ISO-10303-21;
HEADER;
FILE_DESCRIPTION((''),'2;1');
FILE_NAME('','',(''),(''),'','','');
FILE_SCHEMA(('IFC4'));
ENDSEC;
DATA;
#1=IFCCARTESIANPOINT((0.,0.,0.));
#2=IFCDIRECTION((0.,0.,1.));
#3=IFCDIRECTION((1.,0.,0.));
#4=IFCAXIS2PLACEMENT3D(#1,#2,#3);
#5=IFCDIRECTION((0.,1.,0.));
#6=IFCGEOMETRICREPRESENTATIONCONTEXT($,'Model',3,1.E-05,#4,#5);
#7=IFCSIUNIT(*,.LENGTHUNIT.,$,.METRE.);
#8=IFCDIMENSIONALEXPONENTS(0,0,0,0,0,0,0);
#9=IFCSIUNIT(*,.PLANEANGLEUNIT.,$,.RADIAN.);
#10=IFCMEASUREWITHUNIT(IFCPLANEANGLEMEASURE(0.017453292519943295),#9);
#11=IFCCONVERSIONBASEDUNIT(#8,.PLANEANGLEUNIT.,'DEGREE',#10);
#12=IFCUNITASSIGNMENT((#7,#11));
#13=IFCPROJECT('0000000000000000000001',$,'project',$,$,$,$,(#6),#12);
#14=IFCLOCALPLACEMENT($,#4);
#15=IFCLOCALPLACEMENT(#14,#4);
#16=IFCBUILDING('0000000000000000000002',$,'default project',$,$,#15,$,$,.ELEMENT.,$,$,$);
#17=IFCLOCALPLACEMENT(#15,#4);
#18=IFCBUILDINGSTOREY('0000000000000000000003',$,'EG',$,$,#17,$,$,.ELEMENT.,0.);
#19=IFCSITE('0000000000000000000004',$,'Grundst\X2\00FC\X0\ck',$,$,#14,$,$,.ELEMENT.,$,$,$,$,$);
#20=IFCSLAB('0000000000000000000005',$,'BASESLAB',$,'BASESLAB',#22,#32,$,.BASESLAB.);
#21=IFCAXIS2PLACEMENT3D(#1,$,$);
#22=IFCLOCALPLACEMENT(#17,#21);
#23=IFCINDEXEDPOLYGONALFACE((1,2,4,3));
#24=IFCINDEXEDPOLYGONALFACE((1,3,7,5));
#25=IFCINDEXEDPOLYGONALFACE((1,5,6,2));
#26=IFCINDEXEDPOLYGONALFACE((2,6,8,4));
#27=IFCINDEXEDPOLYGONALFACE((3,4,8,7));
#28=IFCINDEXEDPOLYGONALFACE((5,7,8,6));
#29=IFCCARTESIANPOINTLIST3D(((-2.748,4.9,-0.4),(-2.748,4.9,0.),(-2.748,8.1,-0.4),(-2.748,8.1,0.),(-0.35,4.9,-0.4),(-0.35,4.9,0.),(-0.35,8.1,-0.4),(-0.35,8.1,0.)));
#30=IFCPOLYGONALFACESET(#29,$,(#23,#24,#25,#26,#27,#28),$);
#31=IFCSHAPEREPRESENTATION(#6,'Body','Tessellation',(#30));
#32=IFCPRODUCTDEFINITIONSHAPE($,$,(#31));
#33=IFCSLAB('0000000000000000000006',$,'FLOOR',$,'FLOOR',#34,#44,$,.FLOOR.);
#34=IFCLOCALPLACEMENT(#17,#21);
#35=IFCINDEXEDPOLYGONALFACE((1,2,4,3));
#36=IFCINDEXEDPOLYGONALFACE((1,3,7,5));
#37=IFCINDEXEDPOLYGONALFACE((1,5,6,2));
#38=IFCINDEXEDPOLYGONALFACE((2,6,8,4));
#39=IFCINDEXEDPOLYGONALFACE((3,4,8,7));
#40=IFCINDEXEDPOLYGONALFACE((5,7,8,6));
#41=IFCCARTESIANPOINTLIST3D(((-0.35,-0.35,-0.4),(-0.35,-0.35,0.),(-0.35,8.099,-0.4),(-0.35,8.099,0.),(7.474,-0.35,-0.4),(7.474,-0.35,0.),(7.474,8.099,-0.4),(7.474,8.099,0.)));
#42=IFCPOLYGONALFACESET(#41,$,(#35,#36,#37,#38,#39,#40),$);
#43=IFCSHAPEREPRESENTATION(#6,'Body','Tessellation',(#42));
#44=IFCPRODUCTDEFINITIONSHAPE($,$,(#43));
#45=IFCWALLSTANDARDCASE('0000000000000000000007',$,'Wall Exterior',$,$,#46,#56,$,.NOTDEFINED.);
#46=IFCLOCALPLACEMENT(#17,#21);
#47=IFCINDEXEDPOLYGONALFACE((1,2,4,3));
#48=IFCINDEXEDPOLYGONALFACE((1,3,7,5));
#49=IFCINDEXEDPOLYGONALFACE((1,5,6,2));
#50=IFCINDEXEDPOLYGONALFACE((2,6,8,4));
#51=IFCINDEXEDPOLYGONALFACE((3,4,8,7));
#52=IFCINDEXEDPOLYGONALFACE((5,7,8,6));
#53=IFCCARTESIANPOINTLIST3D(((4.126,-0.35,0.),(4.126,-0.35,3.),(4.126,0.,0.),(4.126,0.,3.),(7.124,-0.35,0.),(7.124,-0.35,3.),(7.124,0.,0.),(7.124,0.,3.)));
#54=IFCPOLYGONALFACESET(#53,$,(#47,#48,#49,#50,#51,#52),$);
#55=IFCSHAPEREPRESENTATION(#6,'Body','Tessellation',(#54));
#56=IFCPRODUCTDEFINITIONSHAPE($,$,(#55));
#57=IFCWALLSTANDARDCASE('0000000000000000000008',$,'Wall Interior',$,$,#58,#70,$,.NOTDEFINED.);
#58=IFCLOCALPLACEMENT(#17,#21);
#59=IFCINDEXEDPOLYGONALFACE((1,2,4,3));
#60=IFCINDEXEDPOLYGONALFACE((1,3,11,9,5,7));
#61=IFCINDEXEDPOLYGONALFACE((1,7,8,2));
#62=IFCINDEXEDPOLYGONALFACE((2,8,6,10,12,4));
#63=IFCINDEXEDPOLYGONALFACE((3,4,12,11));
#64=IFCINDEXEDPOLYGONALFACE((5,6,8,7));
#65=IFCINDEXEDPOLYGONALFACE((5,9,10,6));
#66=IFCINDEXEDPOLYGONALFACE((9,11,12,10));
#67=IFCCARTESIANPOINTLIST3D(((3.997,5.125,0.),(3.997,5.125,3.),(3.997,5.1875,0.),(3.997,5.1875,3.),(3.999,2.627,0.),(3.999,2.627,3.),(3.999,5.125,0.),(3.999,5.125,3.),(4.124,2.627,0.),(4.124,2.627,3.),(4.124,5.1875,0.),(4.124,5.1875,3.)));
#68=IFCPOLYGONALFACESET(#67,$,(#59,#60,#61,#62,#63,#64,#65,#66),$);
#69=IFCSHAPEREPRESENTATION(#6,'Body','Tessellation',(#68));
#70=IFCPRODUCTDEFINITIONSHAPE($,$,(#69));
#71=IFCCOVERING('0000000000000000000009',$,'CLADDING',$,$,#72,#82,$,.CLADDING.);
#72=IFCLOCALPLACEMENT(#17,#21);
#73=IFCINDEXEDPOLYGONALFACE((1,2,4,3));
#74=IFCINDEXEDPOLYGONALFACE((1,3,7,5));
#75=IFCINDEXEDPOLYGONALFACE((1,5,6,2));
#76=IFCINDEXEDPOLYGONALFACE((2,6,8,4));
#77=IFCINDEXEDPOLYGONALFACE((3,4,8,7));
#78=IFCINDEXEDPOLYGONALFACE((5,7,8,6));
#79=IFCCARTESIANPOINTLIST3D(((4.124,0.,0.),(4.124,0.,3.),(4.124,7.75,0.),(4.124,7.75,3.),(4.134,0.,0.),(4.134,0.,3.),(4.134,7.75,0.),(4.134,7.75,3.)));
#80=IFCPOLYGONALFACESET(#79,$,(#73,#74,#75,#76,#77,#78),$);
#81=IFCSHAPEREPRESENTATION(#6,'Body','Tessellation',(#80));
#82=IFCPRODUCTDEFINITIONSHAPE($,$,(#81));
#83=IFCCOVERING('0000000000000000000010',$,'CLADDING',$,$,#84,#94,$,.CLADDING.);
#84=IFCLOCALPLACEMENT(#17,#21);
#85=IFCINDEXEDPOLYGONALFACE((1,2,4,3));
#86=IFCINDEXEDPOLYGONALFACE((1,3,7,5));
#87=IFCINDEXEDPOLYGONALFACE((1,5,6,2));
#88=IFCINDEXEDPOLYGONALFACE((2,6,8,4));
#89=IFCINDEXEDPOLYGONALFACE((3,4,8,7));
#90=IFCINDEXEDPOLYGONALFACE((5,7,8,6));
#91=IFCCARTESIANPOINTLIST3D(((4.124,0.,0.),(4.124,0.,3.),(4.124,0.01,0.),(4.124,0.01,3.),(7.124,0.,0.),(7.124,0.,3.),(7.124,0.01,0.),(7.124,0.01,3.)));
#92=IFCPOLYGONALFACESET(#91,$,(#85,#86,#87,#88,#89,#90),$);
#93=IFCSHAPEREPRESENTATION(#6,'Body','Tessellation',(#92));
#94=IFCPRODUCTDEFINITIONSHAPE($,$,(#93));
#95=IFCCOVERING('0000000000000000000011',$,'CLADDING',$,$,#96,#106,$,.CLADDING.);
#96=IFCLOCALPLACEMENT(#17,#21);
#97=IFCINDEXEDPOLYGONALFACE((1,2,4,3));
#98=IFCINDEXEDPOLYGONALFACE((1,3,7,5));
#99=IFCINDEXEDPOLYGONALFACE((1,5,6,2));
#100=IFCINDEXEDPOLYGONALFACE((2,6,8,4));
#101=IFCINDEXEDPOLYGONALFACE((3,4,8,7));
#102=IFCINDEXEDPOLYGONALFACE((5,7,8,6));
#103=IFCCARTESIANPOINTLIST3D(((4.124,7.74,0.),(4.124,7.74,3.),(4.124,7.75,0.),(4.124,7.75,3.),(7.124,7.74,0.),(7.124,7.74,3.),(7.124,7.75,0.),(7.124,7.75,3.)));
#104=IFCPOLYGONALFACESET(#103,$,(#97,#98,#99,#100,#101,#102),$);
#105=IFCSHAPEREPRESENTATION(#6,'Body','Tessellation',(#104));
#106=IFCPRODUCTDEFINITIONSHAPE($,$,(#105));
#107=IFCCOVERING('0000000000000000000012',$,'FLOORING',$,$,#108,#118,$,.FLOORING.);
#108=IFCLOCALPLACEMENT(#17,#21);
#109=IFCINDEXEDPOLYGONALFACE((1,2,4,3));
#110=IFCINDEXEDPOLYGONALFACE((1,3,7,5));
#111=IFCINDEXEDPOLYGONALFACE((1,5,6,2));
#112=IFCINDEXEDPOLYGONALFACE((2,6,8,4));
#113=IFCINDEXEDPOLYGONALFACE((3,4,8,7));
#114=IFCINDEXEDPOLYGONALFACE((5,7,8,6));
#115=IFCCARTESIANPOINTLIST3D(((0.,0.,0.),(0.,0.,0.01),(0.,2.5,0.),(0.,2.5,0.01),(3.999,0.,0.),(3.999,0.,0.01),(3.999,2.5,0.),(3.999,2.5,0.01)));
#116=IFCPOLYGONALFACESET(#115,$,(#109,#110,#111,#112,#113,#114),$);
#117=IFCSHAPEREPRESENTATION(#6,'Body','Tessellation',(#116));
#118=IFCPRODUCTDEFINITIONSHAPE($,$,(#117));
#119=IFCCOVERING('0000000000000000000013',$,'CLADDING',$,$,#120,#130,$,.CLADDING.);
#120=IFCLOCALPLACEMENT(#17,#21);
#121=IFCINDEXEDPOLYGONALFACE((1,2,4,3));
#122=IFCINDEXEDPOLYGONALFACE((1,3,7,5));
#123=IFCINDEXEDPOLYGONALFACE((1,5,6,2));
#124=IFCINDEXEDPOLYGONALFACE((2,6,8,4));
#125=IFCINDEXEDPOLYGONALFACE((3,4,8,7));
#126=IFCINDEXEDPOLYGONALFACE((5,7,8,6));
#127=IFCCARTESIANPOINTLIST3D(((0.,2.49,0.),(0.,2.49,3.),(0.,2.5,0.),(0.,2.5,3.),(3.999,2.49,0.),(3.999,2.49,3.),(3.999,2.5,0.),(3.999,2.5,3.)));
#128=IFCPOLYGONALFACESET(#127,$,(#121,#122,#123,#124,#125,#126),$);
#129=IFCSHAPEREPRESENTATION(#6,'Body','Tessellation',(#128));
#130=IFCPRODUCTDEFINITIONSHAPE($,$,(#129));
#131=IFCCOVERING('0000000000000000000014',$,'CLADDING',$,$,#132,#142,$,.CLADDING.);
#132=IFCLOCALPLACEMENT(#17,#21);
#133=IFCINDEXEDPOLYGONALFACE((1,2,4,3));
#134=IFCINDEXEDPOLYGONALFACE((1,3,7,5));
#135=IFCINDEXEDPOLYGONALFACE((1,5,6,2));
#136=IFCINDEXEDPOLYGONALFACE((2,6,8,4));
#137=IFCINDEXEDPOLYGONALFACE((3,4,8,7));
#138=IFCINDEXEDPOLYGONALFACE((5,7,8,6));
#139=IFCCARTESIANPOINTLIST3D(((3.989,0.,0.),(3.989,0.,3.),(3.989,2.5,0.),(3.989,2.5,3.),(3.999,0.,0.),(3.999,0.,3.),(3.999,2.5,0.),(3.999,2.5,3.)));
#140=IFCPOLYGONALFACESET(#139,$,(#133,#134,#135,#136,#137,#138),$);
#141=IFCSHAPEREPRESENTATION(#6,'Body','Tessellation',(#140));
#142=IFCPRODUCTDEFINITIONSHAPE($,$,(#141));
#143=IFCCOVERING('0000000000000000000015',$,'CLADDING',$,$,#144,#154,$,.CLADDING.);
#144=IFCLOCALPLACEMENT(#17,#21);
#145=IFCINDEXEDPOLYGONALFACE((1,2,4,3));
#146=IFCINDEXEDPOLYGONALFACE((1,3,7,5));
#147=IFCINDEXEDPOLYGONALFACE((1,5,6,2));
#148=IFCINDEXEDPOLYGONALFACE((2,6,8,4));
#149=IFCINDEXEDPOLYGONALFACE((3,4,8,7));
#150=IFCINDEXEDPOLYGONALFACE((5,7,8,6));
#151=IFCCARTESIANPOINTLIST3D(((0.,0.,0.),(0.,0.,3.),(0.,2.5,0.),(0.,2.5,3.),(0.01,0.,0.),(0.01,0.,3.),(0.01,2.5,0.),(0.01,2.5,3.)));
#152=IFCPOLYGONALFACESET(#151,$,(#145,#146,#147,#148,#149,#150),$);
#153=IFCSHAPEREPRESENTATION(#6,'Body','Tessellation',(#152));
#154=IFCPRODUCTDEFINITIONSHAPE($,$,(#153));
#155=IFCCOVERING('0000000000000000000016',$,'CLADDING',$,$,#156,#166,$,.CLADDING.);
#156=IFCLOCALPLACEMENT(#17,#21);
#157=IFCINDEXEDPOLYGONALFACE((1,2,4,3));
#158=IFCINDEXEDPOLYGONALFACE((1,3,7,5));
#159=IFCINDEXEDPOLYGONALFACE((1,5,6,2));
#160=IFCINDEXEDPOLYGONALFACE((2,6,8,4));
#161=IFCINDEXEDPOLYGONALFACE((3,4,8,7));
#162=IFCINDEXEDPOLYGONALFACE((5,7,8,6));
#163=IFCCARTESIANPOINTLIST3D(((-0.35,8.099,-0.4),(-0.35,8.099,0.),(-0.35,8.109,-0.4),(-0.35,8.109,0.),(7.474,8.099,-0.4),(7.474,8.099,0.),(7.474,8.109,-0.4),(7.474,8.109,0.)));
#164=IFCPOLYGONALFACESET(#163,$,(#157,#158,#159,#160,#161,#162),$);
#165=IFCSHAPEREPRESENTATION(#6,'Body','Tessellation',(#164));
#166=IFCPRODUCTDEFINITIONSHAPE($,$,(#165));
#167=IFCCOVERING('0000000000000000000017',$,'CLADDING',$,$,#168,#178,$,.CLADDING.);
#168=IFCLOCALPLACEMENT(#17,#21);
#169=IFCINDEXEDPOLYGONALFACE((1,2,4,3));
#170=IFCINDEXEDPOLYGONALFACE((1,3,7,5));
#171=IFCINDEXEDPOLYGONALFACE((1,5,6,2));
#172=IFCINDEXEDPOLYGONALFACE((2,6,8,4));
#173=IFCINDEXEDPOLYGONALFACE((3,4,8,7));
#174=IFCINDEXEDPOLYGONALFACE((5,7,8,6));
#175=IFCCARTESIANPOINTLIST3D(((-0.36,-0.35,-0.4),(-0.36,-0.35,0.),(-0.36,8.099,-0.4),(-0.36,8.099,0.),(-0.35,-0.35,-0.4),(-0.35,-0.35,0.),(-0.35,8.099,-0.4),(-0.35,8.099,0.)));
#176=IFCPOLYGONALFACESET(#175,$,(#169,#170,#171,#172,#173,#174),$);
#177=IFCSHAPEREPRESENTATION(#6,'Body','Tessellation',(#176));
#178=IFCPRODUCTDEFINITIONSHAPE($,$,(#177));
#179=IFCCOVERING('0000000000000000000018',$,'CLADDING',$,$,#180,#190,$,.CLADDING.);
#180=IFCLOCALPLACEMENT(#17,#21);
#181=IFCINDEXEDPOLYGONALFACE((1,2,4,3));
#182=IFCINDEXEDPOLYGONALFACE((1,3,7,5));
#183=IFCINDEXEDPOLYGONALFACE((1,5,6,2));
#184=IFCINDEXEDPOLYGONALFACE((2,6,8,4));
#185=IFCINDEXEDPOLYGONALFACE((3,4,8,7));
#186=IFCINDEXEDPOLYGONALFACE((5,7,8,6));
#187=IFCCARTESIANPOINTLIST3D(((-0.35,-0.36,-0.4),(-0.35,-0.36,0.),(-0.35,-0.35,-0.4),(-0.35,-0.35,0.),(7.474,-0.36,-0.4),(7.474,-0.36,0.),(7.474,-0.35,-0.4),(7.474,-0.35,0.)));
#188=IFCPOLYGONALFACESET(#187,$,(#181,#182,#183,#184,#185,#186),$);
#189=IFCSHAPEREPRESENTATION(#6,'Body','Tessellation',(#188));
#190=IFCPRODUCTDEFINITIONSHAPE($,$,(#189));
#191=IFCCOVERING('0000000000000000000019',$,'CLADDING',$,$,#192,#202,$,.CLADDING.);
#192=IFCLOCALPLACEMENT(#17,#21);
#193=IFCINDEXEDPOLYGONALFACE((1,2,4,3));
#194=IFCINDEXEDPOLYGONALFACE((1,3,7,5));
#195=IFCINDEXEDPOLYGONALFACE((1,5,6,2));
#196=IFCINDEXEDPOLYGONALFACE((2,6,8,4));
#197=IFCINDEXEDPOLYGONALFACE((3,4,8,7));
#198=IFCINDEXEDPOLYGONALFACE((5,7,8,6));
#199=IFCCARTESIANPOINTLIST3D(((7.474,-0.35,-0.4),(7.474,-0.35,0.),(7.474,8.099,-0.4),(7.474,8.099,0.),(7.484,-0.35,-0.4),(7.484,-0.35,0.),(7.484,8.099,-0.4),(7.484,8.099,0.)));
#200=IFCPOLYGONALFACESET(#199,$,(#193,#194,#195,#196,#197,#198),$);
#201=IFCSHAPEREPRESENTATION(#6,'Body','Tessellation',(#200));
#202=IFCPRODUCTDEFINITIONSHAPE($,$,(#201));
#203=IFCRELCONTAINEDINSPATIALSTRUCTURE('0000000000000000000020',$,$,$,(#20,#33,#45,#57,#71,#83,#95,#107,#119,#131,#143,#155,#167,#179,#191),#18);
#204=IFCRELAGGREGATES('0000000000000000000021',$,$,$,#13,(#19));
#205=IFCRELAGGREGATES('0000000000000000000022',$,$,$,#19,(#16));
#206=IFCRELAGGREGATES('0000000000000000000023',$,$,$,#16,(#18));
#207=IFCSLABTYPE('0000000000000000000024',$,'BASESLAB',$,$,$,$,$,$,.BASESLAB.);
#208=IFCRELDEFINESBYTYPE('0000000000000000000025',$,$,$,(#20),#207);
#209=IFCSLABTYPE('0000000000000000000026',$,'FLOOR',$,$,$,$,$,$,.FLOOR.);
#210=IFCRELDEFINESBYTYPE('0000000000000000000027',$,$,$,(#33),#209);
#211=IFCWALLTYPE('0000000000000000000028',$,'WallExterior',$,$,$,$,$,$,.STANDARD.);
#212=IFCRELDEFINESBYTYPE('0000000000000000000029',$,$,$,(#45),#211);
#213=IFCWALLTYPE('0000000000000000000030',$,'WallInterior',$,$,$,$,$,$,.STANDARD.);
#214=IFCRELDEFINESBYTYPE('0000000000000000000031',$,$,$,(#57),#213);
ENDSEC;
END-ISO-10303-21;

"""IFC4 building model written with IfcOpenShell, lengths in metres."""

from ifc_helpers import new_model, entity, si_unit, converted_unit, direction, frame, origin_with_axes, place, context, project, spatial, polyline, outline, extrude, type_object, element, save


model = new_model("IFC4")

# Units and contexts
model_context = context("Model", 3, precision=1e-05, world=origin_with_axes(), true_north=direction((0.0, 1.0, 0.0)))
ifc_project = project(units=[si_unit("LENGTHUNIT", "METRE"), converted_unit("PLANEANGLEUNIT", "DEGREE", entity("IfcPlaneAngleMeasure", 0.017453292519943295), si_unit("PLANEANGLEUNIT", "RADIAN"), dimensions=[0, 0, 0, 0, 0, 0, 0])], contexts=[model_context])

# Site, building, storey
site_placement = place(None, origin_with_axes())
site = spatial("IfcSite", under=ifc_project, at=site_placement, Name="Grundstück", CompositionType="ELEMENT")
building_placement = place(site_placement, origin_with_axes())
building = spatial("IfcBuilding", under=site, at=building_placement, Name="default project", CompositionType="ELEMENT")
placement_1 = place(building_placement, origin_with_axes())
storey = spatial("IfcBuildingStorey", under=building, at=placement_1, Name="EG", CompositionType="ELEMENT", Elevation=0.0)

# Slabs
slab_type_1 = type_object("IfcSlabType", Name="BASESLAB", PredefinedType="BASESLAB")
slab_1_placement = place(placement_1, frame((0.0, 0.0, -0.4), z_axis=(0.0, 0.0, 1.0), x_axis=(1.0, 0.0, 0.0)))
element("IfcSlab", 1, at=slab_1_placement, inside=storey, type_object=slab_type_1, Name="BASESLAB", ObjectType="BASESLAB", PredefinedType="BASESLAB", context=model_context, shape_type="SweptSolid", body=[
    extrude(outline(polyline([(-0.35, 8.1), (-2.748, 8.1), (-2.748, 4.9), (-0.35, 4.9), (-0.35, 8.1)])), origin_with_axes(), (0.0, 0.0, 1.0), 0.4),
])
slab_type_2 = type_object("IfcSlabType", Name="FLOOR", PredefinedType="FLOOR")
slab_2_placement = place(placement_1, frame((0.0, 0.0, -0.4), z_axis=(0.0, 0.0, 1.0), x_axis=(1.0, 0.0, 0.0)))
element("IfcSlab", 2, at=slab_2_placement, inside=storey, type_object=slab_type_2, Name="FLOOR", ObjectType="FLOOR", PredefinedType="FLOOR", context=model_context, shape_type="SweptSolid", body=[
    extrude(outline(polyline([(7.474, 8.099), (-0.35, 8.099), (-0.35, -0.35), (7.474, -0.35), (7.474, 8.099)])), origin_with_axes(), (0.0, 0.0, 1.0), 0.4),
])

# Walls
wall_type_1 = type_object("IfcWallType", Name="WallExterior", PredefinedType="STANDARD")
placement_2 = place(placement_1, frame((7.299, -0.175, 0.0), z_axis=(0.0, 0.0, 1.0), x_axis=(-1.0, 0.0, 0.0)))
element("IfcWallStandardCase", 3, at=placement_2, inside=storey, type_object=wall_type_1, Name="Wall Exterior", PredefinedType="NOTDEFINED", context=model_context, shape_type="SweptSolid", body=[
    extrude(outline(polyline([(0.175, -0.175), (3.173, -0.175), (3.173, 0.175), (0.175, 0.175), (0.175, -0.175)])), origin_with_axes(), (0.0, 0.0, 1.0), 3.0),
])
wall_type_2 = type_object("IfcWallType", Name="WallInterior", PredefinedType="STANDARD")
wall_1_placement = place(placement_1, frame((4.0615, 5.1875, 0.0), z_axis=(0.0, 0.0, 1.0), x_axis=(0.0, -1.0, 0.0)))
element("IfcWallStandardCase", 4, at=wall_1_placement, inside=storey, type_object=wall_type_2, Name="Wall Interior", PredefinedType="NOTDEFINED", context=model_context, shape_type="SweptSolid", body=[
    extrude(outline(polyline([(0.0, 0.0625), (0.0, -0.0645), (0.0625, -0.0645), (0.0625, -0.0625), (2.5605, -0.0625), (2.5605, 0.0625), (0.0, 0.0625)])), origin_with_axes(), (0.0, 0.0, 1.0), 3.0),
])

# Coverings
element("IfcCovering", 5, at=placement_1, inside=storey, Name="CLADDING", PredefinedType="CLADDING", context=model_context, shape_type="SweptSolid", body=[
    extrude(outline(polyline([(4.134, 0.0), (4.134, 7.75), (4.124, 7.75), (4.124, 0.0), (4.134, 0.0)])), origin_with_axes(), (0.0, 0.0, 1.0), 3.0),
])
element("IfcCovering", 6, at=placement_1, inside=storey, Name="CLADDING", PredefinedType="CLADDING", context=model_context, shape_type="SweptSolid", body=[
    extrude(outline(polyline([(7.124, 0.01), (4.124, 0.01), (4.124, 0.0), (7.124, 0.0), (7.124, 0.01)])), origin_with_axes(), (0.0, 0.0, 1.0), 3.0),
])
element("IfcCovering", 7, at=placement_1, inside=storey, Name="CLADDING", PredefinedType="CLADDING", context=model_context, shape_type="SweptSolid", body=[
    extrude(outline(polyline([(4.124, 7.74), (7.124, 7.74), (7.124, 7.75), (4.124, 7.75), (4.124, 7.74)])), origin_with_axes(), (0.0, 0.0, 1.0), 3.0),
])
element("IfcCovering", 8, at=placement_1, inside=storey, Name="FLOORING", PredefinedType="FLOORING", context=model_context, shape_type="SweptSolid", body=[
    extrude(outline(polyline([(3.999, 2.5), (0.0, 2.5), (0.0, 0.0), (3.999, 0.0), (3.999, 2.5)])), origin_with_axes(), (0.0, 0.0, 1.0), 0.01),
])
element("IfcCovering", 9, at=placement_1, inside=storey, Name="CLADDING", PredefinedType="CLADDING", context=model_context, shape_type="SweptSolid", body=[
    extrude(outline(polyline([(0.0, 2.49), (3.999, 2.49), (3.999, 2.5), (0.0, 2.5), (0.0, 2.49)])), origin_with_axes(), (0.0, 0.0, 1.0), 3.0),
])
element("IfcCovering", 10, at=placement_1, inside=storey, Name="CLADDING", PredefinedType="CLADDING", context=model_context, shape_type="SweptSolid", body=[
    extrude(outline(polyline([(3.989, 2.5), (3.989, 0.0), (3.999, 0.0), (3.999, 2.5), (3.989, 2.5)])), origin_with_axes(), (0.0, 0.0, 1.0), 3.0),
])
element("IfcCovering", 11, at=placement_1, inside=storey, Name="CLADDING", PredefinedType="CLADDING", context=model_context, shape_type="SweptSolid", body=[
    extrude(outline(polyline([(0.01, 0.0), (0.01, 2.5), (0.0, 2.5), (0.0, 0.0), (0.01, 0.0)])), origin_with_axes(), (0.0, 0.0, 1.0), 3.0),
])
covering_1_placement = place(slab_2_placement, origin_with_axes())
element("IfcCovering", 12, at=covering_1_placement, inside=storey, Name="CLADDING", PredefinedType="CLADDING", context=model_context, shape_type="SweptSolid", body=[
    extrude(outline(polyline([(7.474, 8.109), (-0.35, 8.109), (-0.35, 8.099), (7.474, 8.099), (7.474, 8.109)])), origin_with_axes(), (0.0, 0.0, 1.0), 0.4),
])
covering_2_placement = place(slab_2_placement, origin_with_axes())
element("IfcCovering", 13, at=covering_2_placement, inside=storey, Name="CLADDING", PredefinedType="CLADDING", context=model_context, shape_type="SweptSolid", body=[
    extrude(outline(polyline([(-0.36, 8.099), (-0.36, -0.35), (-0.35, -0.35), (-0.35, 8.099), (-0.36, 8.099)])), origin_with_axes(), (0.0, 0.0, 1.0), 0.4),
])
covering_3_placement = place(slab_2_placement, origin_with_axes())
element("IfcCovering", 14, at=covering_3_placement, inside=storey, Name="CLADDING", PredefinedType="CLADDING", context=model_context, shape_type="SweptSolid", body=[
    extrude(outline(polyline([(-0.35, -0.36), (7.474, -0.36), (7.474, -0.35), (-0.35, -0.35), (-0.35, -0.36)])), origin_with_axes(), (0.0, 0.0, 1.0), 0.4),
])
covering_4_placement = place(slab_2_placement, origin_with_axes())
element("IfcCovering", 15, at=covering_4_placement, inside=storey, Name="CLADDING", PredefinedType="CLADDING", context=model_context, shape_type="SweptSolid", body=[
    extrude(outline(polyline([(7.484, -0.35), (7.484, 8.099), (7.474, 8.099), (7.474, -0.35), (7.484, -0.35)])), origin_with_axes(), (0.0, 0.0, 1.0), 0.4),
])

save(model, "model.ifc")
